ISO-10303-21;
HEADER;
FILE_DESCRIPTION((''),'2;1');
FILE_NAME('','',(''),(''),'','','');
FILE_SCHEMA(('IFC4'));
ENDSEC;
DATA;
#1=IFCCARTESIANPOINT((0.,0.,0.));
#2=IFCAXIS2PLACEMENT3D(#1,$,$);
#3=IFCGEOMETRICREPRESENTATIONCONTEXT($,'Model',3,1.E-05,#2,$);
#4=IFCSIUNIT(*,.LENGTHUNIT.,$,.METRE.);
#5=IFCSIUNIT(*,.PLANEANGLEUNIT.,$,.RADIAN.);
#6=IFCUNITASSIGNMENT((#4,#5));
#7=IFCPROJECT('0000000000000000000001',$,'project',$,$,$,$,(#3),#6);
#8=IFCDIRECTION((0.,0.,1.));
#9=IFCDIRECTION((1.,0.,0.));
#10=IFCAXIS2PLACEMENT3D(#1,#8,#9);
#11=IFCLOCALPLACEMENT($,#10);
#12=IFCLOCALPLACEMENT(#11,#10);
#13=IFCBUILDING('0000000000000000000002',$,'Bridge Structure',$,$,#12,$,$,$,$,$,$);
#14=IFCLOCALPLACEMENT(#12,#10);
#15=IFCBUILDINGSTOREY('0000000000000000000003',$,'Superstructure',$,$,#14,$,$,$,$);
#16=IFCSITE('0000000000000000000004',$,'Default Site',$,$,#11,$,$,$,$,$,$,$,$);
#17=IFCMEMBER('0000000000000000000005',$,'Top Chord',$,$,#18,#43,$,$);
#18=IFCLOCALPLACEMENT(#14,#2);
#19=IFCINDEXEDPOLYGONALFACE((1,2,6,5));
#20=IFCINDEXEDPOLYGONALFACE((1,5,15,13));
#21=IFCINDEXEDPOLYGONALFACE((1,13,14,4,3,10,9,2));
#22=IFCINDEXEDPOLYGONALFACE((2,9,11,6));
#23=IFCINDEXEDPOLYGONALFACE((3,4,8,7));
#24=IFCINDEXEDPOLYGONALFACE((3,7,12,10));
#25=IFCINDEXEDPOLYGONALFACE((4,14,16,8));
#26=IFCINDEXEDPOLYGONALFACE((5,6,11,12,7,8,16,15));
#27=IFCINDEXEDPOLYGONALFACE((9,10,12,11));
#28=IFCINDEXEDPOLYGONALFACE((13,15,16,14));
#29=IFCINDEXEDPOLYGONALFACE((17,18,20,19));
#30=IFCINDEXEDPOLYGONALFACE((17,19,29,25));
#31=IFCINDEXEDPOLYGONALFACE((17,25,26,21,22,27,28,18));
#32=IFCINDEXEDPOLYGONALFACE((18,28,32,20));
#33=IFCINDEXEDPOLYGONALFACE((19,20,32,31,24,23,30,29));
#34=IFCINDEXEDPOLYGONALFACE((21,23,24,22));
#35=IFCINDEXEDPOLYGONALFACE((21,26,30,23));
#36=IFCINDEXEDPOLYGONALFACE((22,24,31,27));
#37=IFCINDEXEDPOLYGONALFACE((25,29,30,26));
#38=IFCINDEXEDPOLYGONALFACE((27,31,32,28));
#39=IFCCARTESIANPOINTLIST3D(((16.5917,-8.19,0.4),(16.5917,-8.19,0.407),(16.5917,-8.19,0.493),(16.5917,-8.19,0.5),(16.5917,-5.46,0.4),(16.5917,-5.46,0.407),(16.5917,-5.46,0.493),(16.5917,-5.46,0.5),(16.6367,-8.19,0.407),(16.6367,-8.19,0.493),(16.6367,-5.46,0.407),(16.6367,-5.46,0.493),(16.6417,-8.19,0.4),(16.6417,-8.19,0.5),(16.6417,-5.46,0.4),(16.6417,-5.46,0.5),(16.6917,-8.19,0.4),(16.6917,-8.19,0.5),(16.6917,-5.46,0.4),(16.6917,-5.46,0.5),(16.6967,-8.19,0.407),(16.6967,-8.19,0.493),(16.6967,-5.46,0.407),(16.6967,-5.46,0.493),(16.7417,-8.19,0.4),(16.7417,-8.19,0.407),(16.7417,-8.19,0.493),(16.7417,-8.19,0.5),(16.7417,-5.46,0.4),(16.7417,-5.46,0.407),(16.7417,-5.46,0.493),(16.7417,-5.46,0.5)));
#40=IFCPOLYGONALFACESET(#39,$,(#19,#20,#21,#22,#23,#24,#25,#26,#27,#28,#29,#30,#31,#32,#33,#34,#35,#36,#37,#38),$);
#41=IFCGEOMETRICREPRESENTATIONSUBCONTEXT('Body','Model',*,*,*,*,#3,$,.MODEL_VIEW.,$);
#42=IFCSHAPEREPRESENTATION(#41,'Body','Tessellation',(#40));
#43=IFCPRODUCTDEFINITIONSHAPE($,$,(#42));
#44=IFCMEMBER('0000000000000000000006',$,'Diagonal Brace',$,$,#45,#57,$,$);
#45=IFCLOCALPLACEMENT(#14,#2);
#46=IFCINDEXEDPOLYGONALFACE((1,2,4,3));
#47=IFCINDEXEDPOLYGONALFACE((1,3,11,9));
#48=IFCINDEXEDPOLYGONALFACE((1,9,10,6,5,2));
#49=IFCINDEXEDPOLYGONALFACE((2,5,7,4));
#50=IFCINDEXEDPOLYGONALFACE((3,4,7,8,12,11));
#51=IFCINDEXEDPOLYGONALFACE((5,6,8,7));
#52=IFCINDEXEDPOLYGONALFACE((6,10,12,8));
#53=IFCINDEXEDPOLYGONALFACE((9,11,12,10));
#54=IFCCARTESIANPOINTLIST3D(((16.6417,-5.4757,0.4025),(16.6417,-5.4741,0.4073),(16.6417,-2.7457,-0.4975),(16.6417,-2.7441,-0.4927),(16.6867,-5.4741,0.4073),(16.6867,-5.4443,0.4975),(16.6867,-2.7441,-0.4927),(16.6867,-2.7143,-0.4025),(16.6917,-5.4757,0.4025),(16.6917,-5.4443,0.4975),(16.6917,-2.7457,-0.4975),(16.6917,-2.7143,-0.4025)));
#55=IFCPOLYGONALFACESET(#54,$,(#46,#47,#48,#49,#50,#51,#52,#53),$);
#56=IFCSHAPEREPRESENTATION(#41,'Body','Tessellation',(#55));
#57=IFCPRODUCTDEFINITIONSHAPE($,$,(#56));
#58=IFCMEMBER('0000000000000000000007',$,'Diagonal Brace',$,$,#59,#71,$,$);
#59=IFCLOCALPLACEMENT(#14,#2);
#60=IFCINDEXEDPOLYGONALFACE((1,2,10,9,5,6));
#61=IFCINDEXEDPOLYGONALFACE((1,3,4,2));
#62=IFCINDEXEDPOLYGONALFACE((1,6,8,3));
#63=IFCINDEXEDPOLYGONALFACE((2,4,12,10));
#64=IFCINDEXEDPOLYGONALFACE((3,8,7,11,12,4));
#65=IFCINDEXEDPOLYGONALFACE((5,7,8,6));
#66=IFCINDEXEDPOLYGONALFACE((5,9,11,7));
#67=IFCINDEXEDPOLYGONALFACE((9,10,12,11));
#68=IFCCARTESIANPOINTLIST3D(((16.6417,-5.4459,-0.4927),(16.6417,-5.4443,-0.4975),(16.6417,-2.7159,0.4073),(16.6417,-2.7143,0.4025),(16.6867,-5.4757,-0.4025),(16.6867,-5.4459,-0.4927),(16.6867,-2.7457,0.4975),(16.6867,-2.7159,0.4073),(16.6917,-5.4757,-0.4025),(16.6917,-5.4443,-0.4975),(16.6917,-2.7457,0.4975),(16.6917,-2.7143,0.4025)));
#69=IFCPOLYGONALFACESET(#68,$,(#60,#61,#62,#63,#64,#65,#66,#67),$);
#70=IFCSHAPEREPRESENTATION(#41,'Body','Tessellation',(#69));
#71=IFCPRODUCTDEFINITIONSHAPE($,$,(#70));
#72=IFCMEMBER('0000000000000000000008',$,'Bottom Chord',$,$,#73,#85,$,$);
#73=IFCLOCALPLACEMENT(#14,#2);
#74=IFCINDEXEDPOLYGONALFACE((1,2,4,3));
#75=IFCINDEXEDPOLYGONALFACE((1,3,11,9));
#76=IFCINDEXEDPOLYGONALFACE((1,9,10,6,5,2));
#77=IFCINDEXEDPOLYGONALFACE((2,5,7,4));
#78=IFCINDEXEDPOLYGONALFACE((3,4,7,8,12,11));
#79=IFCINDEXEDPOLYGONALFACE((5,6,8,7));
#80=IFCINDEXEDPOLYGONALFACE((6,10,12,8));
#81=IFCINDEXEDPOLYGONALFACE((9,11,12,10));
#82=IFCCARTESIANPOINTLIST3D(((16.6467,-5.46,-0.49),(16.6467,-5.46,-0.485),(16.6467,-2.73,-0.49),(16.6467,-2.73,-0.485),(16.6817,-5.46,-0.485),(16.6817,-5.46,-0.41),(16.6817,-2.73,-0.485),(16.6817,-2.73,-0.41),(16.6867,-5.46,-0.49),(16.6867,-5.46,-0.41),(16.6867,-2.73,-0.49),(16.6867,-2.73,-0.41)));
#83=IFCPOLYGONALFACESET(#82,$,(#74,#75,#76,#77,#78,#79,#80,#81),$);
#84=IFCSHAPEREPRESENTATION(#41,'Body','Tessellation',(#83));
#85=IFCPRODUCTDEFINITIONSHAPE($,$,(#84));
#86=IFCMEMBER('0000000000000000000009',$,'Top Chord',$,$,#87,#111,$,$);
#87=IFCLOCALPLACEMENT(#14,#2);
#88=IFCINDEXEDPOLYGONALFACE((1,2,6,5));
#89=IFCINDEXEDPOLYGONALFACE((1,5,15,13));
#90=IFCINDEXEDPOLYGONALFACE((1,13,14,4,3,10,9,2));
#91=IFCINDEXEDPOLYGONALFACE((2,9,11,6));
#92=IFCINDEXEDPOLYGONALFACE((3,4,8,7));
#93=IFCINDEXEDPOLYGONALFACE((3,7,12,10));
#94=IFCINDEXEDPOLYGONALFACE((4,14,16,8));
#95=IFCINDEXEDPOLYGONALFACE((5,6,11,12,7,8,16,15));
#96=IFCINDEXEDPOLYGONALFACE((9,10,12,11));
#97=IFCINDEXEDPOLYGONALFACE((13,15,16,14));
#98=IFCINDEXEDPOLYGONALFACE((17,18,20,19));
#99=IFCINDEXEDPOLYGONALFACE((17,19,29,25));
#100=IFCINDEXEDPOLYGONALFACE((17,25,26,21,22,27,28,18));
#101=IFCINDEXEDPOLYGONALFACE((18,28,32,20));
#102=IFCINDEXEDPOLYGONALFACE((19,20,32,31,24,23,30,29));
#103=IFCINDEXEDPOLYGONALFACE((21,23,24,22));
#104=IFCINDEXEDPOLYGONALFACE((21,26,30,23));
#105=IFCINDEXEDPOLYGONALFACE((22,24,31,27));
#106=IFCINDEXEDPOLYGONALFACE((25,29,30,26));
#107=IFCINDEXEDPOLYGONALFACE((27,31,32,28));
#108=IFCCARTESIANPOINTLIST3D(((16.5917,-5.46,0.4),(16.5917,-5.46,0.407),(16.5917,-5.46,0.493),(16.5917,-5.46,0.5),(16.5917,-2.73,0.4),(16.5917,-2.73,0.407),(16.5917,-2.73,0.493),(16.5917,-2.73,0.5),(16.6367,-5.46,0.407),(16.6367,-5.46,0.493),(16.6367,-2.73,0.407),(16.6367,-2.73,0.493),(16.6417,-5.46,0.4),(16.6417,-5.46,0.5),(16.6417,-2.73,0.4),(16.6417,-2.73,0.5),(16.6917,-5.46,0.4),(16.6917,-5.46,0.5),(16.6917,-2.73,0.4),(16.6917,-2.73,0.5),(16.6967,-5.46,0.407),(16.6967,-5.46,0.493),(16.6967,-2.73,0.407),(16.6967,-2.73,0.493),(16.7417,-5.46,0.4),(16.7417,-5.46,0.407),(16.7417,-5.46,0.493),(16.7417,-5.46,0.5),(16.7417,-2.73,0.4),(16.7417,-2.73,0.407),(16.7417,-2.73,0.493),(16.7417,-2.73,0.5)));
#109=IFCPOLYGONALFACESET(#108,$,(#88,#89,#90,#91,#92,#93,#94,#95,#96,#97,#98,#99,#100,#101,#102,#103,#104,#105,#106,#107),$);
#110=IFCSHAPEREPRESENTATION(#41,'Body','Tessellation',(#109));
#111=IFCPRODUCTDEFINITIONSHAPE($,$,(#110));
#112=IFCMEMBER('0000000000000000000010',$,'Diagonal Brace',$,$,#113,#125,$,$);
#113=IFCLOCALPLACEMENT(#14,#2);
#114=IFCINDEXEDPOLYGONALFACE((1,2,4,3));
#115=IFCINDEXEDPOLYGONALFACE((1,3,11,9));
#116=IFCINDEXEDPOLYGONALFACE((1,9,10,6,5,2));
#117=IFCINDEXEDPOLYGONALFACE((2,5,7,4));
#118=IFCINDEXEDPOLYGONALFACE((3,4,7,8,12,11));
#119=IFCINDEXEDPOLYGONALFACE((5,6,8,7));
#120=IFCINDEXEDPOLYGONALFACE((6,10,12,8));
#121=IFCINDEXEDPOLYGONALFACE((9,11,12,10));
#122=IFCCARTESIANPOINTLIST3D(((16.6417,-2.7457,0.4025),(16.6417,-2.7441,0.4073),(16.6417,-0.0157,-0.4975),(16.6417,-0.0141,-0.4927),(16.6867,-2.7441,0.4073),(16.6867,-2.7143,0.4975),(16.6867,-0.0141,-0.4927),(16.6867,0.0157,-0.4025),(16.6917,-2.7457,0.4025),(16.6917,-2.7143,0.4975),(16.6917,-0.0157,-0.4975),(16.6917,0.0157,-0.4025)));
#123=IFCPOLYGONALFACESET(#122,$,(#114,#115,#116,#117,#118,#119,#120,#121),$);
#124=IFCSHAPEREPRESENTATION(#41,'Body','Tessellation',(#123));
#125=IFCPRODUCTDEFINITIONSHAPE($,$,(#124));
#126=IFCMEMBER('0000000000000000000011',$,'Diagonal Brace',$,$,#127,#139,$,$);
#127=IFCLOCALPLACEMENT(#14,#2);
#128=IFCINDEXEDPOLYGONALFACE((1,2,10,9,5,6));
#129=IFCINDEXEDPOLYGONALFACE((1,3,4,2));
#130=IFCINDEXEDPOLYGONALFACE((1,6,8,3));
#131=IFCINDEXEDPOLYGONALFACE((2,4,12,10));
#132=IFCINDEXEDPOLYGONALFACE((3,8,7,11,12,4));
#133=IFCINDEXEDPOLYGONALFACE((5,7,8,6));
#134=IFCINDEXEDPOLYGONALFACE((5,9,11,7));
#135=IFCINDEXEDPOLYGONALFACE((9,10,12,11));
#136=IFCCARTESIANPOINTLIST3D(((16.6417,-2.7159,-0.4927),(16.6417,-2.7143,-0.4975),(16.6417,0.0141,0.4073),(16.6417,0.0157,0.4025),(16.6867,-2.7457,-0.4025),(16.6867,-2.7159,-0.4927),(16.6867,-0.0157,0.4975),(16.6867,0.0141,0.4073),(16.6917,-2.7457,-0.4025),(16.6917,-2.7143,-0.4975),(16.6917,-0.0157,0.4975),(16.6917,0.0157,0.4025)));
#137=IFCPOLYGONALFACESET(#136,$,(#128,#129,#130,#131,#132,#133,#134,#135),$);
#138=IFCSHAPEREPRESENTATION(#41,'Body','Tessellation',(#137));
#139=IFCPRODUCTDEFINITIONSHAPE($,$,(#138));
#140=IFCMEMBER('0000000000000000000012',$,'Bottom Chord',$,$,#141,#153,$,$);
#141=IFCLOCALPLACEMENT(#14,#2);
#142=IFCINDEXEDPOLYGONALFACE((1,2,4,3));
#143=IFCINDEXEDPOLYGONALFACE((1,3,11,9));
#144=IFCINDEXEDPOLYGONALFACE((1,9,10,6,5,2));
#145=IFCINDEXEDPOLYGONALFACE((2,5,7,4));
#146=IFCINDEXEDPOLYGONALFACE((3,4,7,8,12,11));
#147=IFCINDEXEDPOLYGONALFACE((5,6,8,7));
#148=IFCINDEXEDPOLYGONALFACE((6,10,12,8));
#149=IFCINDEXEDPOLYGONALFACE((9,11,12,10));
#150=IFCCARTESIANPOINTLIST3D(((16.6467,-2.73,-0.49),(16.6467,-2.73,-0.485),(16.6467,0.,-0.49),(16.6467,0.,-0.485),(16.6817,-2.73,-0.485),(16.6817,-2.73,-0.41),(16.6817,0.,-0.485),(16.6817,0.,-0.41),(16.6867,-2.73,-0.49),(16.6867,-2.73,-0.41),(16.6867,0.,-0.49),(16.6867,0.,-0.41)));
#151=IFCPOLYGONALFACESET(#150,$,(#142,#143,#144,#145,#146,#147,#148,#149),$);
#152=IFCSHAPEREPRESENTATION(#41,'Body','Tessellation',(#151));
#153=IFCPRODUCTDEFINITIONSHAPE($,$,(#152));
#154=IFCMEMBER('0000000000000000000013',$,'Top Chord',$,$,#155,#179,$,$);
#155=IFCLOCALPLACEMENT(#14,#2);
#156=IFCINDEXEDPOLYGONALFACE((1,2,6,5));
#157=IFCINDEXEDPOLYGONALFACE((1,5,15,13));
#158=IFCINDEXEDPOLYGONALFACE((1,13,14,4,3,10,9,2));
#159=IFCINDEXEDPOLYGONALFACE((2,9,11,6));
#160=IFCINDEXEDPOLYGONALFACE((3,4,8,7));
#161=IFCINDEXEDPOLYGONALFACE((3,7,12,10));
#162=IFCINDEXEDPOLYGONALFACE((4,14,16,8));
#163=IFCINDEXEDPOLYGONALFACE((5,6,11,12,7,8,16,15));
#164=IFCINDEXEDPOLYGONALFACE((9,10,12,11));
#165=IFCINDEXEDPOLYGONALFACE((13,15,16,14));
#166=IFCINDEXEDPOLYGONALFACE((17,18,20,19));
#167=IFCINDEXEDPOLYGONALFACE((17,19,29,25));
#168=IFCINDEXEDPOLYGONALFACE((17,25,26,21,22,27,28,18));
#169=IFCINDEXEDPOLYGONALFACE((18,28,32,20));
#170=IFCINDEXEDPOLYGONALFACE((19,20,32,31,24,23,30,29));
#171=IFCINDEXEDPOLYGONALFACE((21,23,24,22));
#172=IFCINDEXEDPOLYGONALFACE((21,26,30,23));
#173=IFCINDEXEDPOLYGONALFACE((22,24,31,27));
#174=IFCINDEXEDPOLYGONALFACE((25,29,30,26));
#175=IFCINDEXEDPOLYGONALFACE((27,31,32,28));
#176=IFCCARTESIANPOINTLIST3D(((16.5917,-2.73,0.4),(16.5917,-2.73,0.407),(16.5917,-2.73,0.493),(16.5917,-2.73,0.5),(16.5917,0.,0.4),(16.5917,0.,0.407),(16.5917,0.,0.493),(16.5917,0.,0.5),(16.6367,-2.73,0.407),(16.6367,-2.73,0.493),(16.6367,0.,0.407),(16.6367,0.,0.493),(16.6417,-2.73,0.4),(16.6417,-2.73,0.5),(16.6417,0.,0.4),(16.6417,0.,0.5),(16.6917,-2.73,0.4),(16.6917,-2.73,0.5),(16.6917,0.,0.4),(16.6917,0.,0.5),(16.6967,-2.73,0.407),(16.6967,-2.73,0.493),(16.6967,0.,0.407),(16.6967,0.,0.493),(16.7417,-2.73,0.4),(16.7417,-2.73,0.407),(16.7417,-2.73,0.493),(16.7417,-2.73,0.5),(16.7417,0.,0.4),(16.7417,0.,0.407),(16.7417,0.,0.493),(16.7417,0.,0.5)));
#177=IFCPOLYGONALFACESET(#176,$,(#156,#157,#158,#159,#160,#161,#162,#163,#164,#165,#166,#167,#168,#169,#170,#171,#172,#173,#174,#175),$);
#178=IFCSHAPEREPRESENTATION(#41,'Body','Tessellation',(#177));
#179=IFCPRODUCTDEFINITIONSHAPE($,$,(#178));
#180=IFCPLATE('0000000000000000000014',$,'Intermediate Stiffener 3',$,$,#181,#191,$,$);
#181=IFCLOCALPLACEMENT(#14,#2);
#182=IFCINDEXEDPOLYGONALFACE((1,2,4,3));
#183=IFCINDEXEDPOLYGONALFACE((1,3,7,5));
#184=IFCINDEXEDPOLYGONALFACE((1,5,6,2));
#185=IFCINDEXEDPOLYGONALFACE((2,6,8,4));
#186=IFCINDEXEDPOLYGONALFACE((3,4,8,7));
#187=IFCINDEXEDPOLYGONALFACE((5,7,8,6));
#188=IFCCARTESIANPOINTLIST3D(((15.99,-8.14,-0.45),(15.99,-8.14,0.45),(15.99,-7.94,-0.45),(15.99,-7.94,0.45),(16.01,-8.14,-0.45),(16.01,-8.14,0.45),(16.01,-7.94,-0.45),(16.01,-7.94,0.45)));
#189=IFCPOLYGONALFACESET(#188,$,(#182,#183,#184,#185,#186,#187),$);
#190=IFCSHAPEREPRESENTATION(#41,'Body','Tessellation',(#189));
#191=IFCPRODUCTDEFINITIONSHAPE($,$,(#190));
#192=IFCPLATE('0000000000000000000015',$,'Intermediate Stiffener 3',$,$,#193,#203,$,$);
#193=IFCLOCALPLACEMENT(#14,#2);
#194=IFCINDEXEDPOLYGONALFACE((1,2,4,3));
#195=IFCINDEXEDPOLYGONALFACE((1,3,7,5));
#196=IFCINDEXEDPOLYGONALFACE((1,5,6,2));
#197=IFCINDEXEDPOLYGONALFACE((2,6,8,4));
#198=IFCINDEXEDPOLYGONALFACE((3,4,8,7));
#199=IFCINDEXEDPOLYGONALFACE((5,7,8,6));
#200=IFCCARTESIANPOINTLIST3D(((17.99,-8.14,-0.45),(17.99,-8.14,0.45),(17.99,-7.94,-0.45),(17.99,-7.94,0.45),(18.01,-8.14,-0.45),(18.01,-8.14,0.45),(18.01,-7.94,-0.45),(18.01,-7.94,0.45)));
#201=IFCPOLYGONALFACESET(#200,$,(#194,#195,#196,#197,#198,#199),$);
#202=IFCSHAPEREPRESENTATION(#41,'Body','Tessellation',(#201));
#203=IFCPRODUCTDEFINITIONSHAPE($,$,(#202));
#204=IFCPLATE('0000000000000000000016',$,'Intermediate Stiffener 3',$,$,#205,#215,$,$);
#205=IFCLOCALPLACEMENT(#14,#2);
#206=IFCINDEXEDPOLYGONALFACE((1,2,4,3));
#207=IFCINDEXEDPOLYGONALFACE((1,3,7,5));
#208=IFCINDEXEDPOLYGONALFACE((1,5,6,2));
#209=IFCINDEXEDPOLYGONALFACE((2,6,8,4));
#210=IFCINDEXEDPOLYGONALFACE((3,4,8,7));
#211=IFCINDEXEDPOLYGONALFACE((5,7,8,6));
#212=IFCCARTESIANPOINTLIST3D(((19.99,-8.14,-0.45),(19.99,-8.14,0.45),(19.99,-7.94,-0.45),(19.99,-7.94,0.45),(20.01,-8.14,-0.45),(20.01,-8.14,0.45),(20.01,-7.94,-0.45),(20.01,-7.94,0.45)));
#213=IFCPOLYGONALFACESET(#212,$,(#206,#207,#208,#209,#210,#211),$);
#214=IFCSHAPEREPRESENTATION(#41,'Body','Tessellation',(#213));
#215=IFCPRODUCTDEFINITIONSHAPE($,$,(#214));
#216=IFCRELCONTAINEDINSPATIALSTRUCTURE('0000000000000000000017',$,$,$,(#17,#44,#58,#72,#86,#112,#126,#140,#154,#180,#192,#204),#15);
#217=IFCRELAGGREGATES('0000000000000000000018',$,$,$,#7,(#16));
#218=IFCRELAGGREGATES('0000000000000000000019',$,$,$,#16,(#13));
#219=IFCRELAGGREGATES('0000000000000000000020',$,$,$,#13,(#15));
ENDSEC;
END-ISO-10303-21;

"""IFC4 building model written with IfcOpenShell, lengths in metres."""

from ifc_helpers import new_model, si_unit, frame, origin, origin_with_axes, origin_2d_with_axis, place, context, subcontext, project, spatial, polyline, rectangle, l_section, outline, composite_profile, extrude, element, save


model = new_model("IFC4")

# Units and contexts
model_context = context("Model", 3, precision=1e-05, world=origin())
body_context = subcontext(model_context, "Body", "Model", "MODEL_VIEW")
ifc_project = project(units=[si_unit("LENGTHUNIT", "METRE"), si_unit("PLANEANGLEUNIT", "RADIAN")], contexts=[model_context])

# Site, building, storey
site_placement = place(None, origin_with_axes())
site = spatial("IfcSite", under=ifc_project, at=site_placement, Name="Default Site")
building_placement = place(site_placement, origin_with_axes())
building = spatial("IfcBuilding", under=site, at=building_placement, Name="Bridge Structure")
storey_placement = place(building_placement, origin_with_axes())
storey = spatial("IfcBuildingStorey", under=building, at=storey_placement, Name="Superstructure")

# Members
member_1_placement = place(storey_placement, frame((16.6667, -8.19, 0.45), z_axis=(0.0, 1.0, 0.0), x_axis=(-1.0, 0.0, 0.0)))
element("IfcMember", 1, at=member_1_placement, inside=storey, Name="Top Chord", context=body_context, shape_type="SweptSolid", body=[
    extrude(composite_profile([outline(polyline([(-0.025, -0.05), (-0.025, 0.05), (-0.075, 0.05), (-0.075, 0.043), (-0.03, 0.043), (-0.03, -0.043), (-0.075, -0.043), (-0.075, -0.05), (-0.025, -0.05)])), outline(polyline([(0.025, -0.05), (0.075, -0.05), (0.075, -0.043), (0.03, -0.043), (0.03, 0.043), (0.075, 0.043), (0.075, 0.05), (0.025, 0.05), (0.025, -0.05)]))]), origin_with_axes(), (0.0, 0.0, 1.0), 2.73),
])
for number, where, z_axis, x_axis, name in (
    (2, (16.6667, -5.46, 0.45), (0.0, 0.949722, -0.313095), (-1.0, 0.0, 0.0), "Diagonal Brace"),
    (3, (16.6667, -5.46, -0.45), (0.0, 0.949722, 0.313095), (-1.0, 0.0, 0.0), "Diagonal Brace"),
):
    element("IfcMember", number, at=place(storey_placement, frame(where, z_axis=z_axis, x_axis=x_axis)), inside=storey, Name=name, context=body_context, shape_type="SweptSolid", body=[
        extrude(l_section(Depth=0.1, Width=0.05, Thickness=0.005, at=origin_2d_with_axis()), origin_with_axes(), (0.0, 0.0, 1.0), 2.8745),
    ])
member_2_placement = place(storey_placement, frame((16.6667, -5.46, -0.45), z_axis=(0.0, 1.0, 0.0), x_axis=(-1.0, 0.0, 0.0)))
element("IfcMember", 4, at=member_2_placement, inside=storey, Name="Bottom Chord", context=body_context, shape_type="SweptSolid", body=[
    extrude(l_section(Depth=0.08, Width=0.04, Thickness=0.005, at=origin_2d_with_axis()), origin_with_axes(), (0.0, 0.0, 1.0), 2.73),
])
member_3_placement = place(storey_placement, frame((16.6667, -5.46, 0.45), z_axis=(0.0, 1.0, 0.0), x_axis=(-1.0, 0.0, 0.0)))
element("IfcMember", 5, at=member_3_placement, inside=storey, Name="Top Chord", context=body_context, shape_type="SweptSolid", body=[
    extrude(composite_profile([outline(polyline([(-0.025, -0.05), (-0.025, 0.05), (-0.075, 0.05), (-0.075, 0.043), (-0.03, 0.043), (-0.03, -0.043), (-0.075, -0.043), (-0.075, -0.05), (-0.025, -0.05)])), outline(polyline([(0.025, -0.05), (0.075, -0.05), (0.075, -0.043), (0.03, -0.043), (0.03, 0.043), (0.075, 0.043), (0.075, 0.05), (0.025, 0.05), (0.025, -0.05)]))]), origin_with_axes(), (0.0, 0.0, 1.0), 2.73),
])
for number, where, z_axis, x_axis, name in (
    (6, (16.6667, -2.73, 0.45), (0.0, 0.949722, -0.313095), (-1.0, 0.0, 0.0), "Diagonal Brace"),
    (7, (16.6667, -2.73, -0.45), (0.0, 0.949722, 0.313095), (-1.0, 0.0, 0.0), "Diagonal Brace"),
):
    element("IfcMember", number, at=place(storey_placement, frame(where, z_axis=z_axis, x_axis=x_axis)), inside=storey, Name=name, context=body_context, shape_type="SweptSolid", body=[
        extrude(l_section(Depth=0.1, Width=0.05, Thickness=0.005, at=origin_2d_with_axis()), origin_with_axes(), (0.0, 0.0, 1.0), 2.8745),
    ])
member_4_placement = place(storey_placement, frame((16.6667, -2.73, -0.45), z_axis=(0.0, 1.0, 0.0), x_axis=(-1.0, 0.0, 0.0)))
element("IfcMember", 8, at=member_4_placement, inside=storey, Name="Bottom Chord", context=body_context, shape_type="SweptSolid", body=[
    extrude(l_section(Depth=0.08, Width=0.04, Thickness=0.005, at=origin_2d_with_axis()), origin_with_axes(), (0.0, 0.0, 1.0), 2.73),
])
member_5_placement = place(storey_placement, frame((16.6667, -2.73, 0.45), z_axis=(0.0, 1.0, 0.0), x_axis=(-1.0, 0.0, 0.0)))
element("IfcMember", 9, at=member_5_placement, inside=storey, Name="Top Chord", context=body_context, shape_type="SweptSolid", body=[
    extrude(composite_profile([outline(polyline([(-0.025, -0.05), (-0.025, 0.05), (-0.075, 0.05), (-0.075, 0.043), (-0.03, 0.043), (-0.03, -0.043), (-0.075, -0.043), (-0.075, -0.05), (-0.025, -0.05)])), outline(polyline([(0.025, -0.05), (0.075, -0.05), (0.075, -0.043), (0.03, -0.043), (0.03, 0.043), (0.075, 0.043), (0.075, 0.05), (0.025, 0.05), (0.025, -0.05)]))]), origin_with_axes(), (0.0, 0.0, 1.0), 2.73),
])

# Plates
for number, where, z_axis, x_axis, name in (
    (10, (16.0, -8.04, -0.45), (0.0, 0.0, 1.0), (1.0, 0.0, 0.0), "Intermediate Stiffener 3"),
    (11, (18.0, -8.04, -0.45), (0.0, 0.0, 1.0), (1.0, 0.0, 0.0), "Intermediate Stiffener 3"),
    (12, (20.0, -8.04, -0.45), (0.0, 0.0, 1.0), (1.0, 0.0, 0.0), "Intermediate Stiffener 3"),
):
    element("IfcPlate", number, at=place(storey_placement, frame(where, z_axis=z_axis, x_axis=x_axis)), inside=storey, Name=name, context=body_context, shape_type="SweptSolid", body=[
        extrude(rectangle(XDim=0.02, YDim=0.2, at=origin_2d_with_axis()), origin_with_axes(), (0.0, 0.0, 1.0), 0.9),
    ])

save(model, "model.ifc")
